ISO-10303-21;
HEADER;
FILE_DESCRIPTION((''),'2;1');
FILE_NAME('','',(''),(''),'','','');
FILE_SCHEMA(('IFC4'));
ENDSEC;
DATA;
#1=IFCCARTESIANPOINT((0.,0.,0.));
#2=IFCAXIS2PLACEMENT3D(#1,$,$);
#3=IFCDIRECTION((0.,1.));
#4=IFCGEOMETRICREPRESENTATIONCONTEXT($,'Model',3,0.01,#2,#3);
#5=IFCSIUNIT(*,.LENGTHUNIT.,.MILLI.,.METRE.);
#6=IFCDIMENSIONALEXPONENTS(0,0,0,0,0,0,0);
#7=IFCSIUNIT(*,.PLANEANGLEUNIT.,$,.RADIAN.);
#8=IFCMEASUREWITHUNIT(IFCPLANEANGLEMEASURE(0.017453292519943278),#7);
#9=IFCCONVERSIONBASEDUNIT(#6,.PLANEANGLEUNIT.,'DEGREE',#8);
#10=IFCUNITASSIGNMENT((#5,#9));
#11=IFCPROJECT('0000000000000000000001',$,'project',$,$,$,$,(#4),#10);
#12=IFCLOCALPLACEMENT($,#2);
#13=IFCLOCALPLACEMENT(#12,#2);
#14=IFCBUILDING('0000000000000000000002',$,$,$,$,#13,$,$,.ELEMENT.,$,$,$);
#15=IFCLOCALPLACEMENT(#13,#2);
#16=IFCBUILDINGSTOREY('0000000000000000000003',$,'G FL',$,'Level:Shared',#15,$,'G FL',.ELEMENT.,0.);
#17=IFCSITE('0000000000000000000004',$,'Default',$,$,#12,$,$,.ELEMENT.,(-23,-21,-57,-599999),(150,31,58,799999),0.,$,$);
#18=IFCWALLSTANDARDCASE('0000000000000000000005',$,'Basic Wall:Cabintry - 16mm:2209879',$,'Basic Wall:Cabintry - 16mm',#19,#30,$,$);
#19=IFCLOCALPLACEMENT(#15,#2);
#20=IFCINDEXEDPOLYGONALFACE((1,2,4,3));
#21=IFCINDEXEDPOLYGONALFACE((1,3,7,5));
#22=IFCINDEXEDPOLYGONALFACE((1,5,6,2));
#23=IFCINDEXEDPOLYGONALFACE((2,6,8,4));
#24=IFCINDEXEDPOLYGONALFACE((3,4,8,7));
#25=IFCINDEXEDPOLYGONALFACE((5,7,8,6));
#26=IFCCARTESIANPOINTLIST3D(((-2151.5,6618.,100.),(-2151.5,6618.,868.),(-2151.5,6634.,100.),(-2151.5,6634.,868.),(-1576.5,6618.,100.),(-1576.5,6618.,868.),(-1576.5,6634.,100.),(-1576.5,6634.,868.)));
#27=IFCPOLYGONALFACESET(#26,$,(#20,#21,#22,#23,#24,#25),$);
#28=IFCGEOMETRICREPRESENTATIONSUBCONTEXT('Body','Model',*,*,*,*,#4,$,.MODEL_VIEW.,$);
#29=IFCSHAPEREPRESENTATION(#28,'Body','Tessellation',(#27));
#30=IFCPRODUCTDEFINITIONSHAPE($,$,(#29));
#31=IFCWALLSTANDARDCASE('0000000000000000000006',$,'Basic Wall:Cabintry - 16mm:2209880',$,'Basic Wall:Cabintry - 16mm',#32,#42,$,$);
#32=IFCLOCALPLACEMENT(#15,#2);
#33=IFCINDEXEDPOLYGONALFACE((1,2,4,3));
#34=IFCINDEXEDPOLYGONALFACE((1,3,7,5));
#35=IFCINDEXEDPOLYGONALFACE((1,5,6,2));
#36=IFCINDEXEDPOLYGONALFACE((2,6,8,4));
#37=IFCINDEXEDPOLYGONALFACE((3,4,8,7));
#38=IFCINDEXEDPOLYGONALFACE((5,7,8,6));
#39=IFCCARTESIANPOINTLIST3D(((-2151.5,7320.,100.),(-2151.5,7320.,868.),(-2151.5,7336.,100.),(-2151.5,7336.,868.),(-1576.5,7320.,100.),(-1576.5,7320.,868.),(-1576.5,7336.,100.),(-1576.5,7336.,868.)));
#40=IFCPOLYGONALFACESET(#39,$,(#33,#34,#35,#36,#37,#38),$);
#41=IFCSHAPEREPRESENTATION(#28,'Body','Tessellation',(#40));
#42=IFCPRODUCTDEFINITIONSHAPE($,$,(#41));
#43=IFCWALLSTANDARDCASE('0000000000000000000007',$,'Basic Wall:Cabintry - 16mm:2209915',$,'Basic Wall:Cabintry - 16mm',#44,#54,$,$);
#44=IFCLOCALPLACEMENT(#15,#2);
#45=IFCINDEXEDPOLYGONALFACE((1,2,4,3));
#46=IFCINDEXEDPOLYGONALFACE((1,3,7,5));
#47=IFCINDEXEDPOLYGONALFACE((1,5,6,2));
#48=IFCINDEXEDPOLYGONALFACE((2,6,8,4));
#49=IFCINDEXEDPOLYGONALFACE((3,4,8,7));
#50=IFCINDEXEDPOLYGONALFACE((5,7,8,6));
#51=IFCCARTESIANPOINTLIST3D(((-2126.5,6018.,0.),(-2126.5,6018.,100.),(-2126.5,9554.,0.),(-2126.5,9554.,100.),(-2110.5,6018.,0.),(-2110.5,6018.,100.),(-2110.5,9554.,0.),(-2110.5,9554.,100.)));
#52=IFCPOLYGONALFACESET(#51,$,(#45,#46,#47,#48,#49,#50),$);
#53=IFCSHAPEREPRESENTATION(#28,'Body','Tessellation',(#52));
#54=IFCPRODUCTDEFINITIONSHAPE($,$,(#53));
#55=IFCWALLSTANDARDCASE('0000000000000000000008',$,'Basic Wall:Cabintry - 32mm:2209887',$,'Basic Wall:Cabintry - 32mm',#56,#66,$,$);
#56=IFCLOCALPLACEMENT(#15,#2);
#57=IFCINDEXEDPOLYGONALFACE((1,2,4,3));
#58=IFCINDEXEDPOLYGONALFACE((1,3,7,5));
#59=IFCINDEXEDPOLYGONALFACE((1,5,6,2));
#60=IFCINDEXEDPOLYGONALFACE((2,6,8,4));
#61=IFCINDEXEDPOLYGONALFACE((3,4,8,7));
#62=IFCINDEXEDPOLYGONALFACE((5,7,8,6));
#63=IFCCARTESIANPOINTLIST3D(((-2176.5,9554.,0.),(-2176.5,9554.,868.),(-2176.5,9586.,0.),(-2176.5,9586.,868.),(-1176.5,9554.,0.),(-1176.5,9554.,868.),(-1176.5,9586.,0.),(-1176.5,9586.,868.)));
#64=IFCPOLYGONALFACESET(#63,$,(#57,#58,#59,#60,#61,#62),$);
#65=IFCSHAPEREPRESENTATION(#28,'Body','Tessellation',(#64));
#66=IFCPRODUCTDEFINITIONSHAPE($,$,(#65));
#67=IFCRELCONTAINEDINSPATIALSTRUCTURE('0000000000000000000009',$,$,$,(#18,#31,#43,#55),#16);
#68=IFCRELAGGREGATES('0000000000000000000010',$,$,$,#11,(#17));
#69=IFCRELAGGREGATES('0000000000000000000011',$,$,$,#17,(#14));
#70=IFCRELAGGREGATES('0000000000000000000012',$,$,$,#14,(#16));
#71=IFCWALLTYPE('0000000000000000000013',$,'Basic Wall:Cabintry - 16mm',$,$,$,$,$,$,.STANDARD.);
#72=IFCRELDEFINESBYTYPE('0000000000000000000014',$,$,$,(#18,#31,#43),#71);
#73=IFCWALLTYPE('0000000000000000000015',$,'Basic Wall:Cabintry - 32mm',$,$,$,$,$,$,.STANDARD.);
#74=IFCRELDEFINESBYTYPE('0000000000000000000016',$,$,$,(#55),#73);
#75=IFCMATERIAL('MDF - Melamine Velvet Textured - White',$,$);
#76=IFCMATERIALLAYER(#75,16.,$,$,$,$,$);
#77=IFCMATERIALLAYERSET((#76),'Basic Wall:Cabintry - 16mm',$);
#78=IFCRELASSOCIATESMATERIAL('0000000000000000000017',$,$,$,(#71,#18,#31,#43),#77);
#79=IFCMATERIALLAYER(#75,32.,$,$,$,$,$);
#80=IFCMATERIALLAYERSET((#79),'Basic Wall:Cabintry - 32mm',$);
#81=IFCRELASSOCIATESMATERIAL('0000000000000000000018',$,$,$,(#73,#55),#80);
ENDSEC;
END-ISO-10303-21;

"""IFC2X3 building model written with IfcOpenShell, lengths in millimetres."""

from ifc_helpers import new_model, entity, si_unit, converted_unit, direction, frame, frame_2d, origin, place, context, subcontext, project, spatial, polyline, rectangle, extrude, clip, bounded_halfspace, material, layer, layer_set, layer_usage, type_object, element, save


model = new_model("IFC2X3")

# Units and contexts
model_context = context("Model", 3, precision=0.01, world=origin(), true_north=direction((0.0, 1.0)))
body_context = subcontext(model_context, "Body", "Model", "MODEL_VIEW")
ifc_project = project(units=[si_unit("LENGTHUNIT", "METRE", prefix="MILLI"), converted_unit("PLANEANGLEUNIT", "DEGREE", entity("IfcPlaneAngleMeasure", 0.017453292519943278), si_unit("PLANEANGLEUNIT", "RADIAN"), dimensions=[0, 0, 0, 0, 0, 0, 0])], contexts=[model_context])

# Site, building, storey
site_placement = place(None, origin())
site = spatial("IfcSite", under=ifc_project, at=site_placement, Name="Default", CompositionType="ELEMENT", RefLatitude=(-23, -21, -57, -599999), RefLongitude=(150, 31, 58, 799999), RefElevation=0.0)
building_placement = place(site_placement, origin())
building = spatial("IfcBuilding", under=site, at=building_placement, CompositionType="ELEMENT")
storey_placement = place(building_placement, origin())
storey = spatial("IfcBuildingStorey", under=building, at=storey_placement, Name="G FL", ObjectType="Level:Shared", LongName="G FL", CompositionType="ELEMENT", Elevation=0.0)

# Walls
ifc_material = material(Name="MDF - Melamine Velvet Textured - White")
ifc_layer_1 = layer(ifc_material, 16.0)
ifc_layer_set_1 = layer_set([ifc_layer_1], Name="Basic Wall:Cabintry - 16mm")
ifc_layer_usage_1 = layer_usage(ifc_layer_set_1, "AXIS2", "POSITIVE", -8.0)
wall_type_1 = type_object("IfcWallType", Name="Basic Wall:Cabintry - 16mm", PredefinedType="STANDARD", material=ifc_layer_set_1)
wall_1_placement = place(storey_placement, frame((-2151.5, 6626.0, 100.0)))
element("IfcWallStandardCase", 1, at=wall_1_placement, inside=storey, type_object=wall_type_1, material=ifc_layer_usage_1, Name="Basic Wall:Cabintry - 16mm:2209879", ObjectType="Basic Wall:Cabintry - 16mm", context=body_context, shape_type="Clipping", body=[
    clip(extrude(rectangle(XDim=575.0, YDim=16.0, at=frame_2d((287.5, 0.0), x_axis=(-1.0, 0.0))), origin(), (0.0, 0.0, 1.0), 768.0), bounded_halfspace(frame((0.0, -8.0, 768.0), z_axis=(0.0, 0.0, -1.0), x_axis=(0.0, -1.0, 0.0)), True, frame((0.0, -8.0, 768.0)), polyline([(0.0, 0.0), (575.0, 0.0), (575.0, 16.0), (0.0, 16.0), (0.0, 0.0)]))),
])
ifc_layer_usage_2 = layer_usage(ifc_layer_set_1, "AXIS2", "POSITIVE", -8.0)
wall_2_placement = place(storey_placement, frame((-2151.5, 7328.0, 100.0)))
element("IfcWallStandardCase", 2, at=wall_2_placement, inside=storey, type_object=wall_type_1, material=ifc_layer_usage_2, Name="Basic Wall:Cabintry - 16mm:2209880", ObjectType="Basic Wall:Cabintry - 16mm", context=body_context, shape_type="Clipping", body=[
    clip(extrude(rectangle(XDim=575.0, YDim=16.0, at=frame_2d((287.5, 0.0), x_axis=(-1.0, 0.0))), origin(), (0.0, 0.0, 1.0), 768.0), bounded_halfspace(frame((0.0, -8.0, 768.0), z_axis=(0.0, 0.0, -1.0), x_axis=(0.0, -1.0, 0.0)), True, frame((0.0, -8.0, 768.0)), polyline([(0.0, 0.0), (575.0, 0.0), (575.0, 16.0), (0.0, 16.0), (0.0, 0.0)]))),
])
ifc_layer_usage_3 = layer_usage(ifc_layer_set_1, "AXIS2", "NEGATIVE", 8.0)
wall_3_placement = place(storey_placement, frame((-2118.5, 9554.0, 0.0), z_axis=(0.0, 0.0, 1.0), x_axis=(0.0, -1.0, 0.0)))
element("IfcWallStandardCase", 3, at=wall_3_placement, inside=storey, type_object=wall_type_1, material=ifc_layer_usage_3, Name="Basic Wall:Cabintry - 16mm:2209915", ObjectType="Basic Wall:Cabintry - 16mm", context=body_context, shape_type="SweptSolid", body=[
    extrude(rectangle(XDim=3536.0, YDim=16.0, at=frame_2d((1768.0, 0.0), x_axis=(-1.0, 0.0))), origin(), (0.0, 0.0, 1.0), 100.0),
])
ifc_layer_2 = layer(ifc_material, 32.0)
ifc_layer_set_2 = layer_set([ifc_layer_2], Name="Basic Wall:Cabintry - 32mm")
wall_type_2 = type_object("IfcWallType", Name="Basic Wall:Cabintry - 32mm", PredefinedType="STANDARD", material=ifc_layer_set_2)
ifc_layer_usage_4 = layer_usage(ifc_layer_set_2, "AXIS2", "POSITIVE", -16.0)
wall_4_placement = place(storey_placement, frame((-2176.5, 9570.0, 0.0)))
element("IfcWallStandardCase", 4, at=wall_4_placement, inside=storey, type_object=wall_type_2, material=ifc_layer_usage_4, Name="Basic Wall:Cabintry - 32mm:2209887", ObjectType="Basic Wall:Cabintry - 32mm", context=body_context, shape_type="Clipping", body=[
    clip(extrude(rectangle(XDim=1000.0, YDim=32.0, at=frame_2d((500.0, 0.0), x_axis=(-1.0, 0.0))), origin(), (0.0, 0.0, 1.0), 868.0), bounded_halfspace(frame((0.0, -16.0, 868.0), z_axis=(0.0, 0.0, -1.0), x_axis=(0.0, -1.0, 0.0)), True, frame((0.0, -16.0, 868.0)), polyline([(0.0, 0.0), (600.0, 0.0), (632.0, 0.0), (1000.0, 0.0), (1000.0, 32.0), (0.0, 32.0), (0.0, 0.0)]))),
])

save(model, "model.ifc")
